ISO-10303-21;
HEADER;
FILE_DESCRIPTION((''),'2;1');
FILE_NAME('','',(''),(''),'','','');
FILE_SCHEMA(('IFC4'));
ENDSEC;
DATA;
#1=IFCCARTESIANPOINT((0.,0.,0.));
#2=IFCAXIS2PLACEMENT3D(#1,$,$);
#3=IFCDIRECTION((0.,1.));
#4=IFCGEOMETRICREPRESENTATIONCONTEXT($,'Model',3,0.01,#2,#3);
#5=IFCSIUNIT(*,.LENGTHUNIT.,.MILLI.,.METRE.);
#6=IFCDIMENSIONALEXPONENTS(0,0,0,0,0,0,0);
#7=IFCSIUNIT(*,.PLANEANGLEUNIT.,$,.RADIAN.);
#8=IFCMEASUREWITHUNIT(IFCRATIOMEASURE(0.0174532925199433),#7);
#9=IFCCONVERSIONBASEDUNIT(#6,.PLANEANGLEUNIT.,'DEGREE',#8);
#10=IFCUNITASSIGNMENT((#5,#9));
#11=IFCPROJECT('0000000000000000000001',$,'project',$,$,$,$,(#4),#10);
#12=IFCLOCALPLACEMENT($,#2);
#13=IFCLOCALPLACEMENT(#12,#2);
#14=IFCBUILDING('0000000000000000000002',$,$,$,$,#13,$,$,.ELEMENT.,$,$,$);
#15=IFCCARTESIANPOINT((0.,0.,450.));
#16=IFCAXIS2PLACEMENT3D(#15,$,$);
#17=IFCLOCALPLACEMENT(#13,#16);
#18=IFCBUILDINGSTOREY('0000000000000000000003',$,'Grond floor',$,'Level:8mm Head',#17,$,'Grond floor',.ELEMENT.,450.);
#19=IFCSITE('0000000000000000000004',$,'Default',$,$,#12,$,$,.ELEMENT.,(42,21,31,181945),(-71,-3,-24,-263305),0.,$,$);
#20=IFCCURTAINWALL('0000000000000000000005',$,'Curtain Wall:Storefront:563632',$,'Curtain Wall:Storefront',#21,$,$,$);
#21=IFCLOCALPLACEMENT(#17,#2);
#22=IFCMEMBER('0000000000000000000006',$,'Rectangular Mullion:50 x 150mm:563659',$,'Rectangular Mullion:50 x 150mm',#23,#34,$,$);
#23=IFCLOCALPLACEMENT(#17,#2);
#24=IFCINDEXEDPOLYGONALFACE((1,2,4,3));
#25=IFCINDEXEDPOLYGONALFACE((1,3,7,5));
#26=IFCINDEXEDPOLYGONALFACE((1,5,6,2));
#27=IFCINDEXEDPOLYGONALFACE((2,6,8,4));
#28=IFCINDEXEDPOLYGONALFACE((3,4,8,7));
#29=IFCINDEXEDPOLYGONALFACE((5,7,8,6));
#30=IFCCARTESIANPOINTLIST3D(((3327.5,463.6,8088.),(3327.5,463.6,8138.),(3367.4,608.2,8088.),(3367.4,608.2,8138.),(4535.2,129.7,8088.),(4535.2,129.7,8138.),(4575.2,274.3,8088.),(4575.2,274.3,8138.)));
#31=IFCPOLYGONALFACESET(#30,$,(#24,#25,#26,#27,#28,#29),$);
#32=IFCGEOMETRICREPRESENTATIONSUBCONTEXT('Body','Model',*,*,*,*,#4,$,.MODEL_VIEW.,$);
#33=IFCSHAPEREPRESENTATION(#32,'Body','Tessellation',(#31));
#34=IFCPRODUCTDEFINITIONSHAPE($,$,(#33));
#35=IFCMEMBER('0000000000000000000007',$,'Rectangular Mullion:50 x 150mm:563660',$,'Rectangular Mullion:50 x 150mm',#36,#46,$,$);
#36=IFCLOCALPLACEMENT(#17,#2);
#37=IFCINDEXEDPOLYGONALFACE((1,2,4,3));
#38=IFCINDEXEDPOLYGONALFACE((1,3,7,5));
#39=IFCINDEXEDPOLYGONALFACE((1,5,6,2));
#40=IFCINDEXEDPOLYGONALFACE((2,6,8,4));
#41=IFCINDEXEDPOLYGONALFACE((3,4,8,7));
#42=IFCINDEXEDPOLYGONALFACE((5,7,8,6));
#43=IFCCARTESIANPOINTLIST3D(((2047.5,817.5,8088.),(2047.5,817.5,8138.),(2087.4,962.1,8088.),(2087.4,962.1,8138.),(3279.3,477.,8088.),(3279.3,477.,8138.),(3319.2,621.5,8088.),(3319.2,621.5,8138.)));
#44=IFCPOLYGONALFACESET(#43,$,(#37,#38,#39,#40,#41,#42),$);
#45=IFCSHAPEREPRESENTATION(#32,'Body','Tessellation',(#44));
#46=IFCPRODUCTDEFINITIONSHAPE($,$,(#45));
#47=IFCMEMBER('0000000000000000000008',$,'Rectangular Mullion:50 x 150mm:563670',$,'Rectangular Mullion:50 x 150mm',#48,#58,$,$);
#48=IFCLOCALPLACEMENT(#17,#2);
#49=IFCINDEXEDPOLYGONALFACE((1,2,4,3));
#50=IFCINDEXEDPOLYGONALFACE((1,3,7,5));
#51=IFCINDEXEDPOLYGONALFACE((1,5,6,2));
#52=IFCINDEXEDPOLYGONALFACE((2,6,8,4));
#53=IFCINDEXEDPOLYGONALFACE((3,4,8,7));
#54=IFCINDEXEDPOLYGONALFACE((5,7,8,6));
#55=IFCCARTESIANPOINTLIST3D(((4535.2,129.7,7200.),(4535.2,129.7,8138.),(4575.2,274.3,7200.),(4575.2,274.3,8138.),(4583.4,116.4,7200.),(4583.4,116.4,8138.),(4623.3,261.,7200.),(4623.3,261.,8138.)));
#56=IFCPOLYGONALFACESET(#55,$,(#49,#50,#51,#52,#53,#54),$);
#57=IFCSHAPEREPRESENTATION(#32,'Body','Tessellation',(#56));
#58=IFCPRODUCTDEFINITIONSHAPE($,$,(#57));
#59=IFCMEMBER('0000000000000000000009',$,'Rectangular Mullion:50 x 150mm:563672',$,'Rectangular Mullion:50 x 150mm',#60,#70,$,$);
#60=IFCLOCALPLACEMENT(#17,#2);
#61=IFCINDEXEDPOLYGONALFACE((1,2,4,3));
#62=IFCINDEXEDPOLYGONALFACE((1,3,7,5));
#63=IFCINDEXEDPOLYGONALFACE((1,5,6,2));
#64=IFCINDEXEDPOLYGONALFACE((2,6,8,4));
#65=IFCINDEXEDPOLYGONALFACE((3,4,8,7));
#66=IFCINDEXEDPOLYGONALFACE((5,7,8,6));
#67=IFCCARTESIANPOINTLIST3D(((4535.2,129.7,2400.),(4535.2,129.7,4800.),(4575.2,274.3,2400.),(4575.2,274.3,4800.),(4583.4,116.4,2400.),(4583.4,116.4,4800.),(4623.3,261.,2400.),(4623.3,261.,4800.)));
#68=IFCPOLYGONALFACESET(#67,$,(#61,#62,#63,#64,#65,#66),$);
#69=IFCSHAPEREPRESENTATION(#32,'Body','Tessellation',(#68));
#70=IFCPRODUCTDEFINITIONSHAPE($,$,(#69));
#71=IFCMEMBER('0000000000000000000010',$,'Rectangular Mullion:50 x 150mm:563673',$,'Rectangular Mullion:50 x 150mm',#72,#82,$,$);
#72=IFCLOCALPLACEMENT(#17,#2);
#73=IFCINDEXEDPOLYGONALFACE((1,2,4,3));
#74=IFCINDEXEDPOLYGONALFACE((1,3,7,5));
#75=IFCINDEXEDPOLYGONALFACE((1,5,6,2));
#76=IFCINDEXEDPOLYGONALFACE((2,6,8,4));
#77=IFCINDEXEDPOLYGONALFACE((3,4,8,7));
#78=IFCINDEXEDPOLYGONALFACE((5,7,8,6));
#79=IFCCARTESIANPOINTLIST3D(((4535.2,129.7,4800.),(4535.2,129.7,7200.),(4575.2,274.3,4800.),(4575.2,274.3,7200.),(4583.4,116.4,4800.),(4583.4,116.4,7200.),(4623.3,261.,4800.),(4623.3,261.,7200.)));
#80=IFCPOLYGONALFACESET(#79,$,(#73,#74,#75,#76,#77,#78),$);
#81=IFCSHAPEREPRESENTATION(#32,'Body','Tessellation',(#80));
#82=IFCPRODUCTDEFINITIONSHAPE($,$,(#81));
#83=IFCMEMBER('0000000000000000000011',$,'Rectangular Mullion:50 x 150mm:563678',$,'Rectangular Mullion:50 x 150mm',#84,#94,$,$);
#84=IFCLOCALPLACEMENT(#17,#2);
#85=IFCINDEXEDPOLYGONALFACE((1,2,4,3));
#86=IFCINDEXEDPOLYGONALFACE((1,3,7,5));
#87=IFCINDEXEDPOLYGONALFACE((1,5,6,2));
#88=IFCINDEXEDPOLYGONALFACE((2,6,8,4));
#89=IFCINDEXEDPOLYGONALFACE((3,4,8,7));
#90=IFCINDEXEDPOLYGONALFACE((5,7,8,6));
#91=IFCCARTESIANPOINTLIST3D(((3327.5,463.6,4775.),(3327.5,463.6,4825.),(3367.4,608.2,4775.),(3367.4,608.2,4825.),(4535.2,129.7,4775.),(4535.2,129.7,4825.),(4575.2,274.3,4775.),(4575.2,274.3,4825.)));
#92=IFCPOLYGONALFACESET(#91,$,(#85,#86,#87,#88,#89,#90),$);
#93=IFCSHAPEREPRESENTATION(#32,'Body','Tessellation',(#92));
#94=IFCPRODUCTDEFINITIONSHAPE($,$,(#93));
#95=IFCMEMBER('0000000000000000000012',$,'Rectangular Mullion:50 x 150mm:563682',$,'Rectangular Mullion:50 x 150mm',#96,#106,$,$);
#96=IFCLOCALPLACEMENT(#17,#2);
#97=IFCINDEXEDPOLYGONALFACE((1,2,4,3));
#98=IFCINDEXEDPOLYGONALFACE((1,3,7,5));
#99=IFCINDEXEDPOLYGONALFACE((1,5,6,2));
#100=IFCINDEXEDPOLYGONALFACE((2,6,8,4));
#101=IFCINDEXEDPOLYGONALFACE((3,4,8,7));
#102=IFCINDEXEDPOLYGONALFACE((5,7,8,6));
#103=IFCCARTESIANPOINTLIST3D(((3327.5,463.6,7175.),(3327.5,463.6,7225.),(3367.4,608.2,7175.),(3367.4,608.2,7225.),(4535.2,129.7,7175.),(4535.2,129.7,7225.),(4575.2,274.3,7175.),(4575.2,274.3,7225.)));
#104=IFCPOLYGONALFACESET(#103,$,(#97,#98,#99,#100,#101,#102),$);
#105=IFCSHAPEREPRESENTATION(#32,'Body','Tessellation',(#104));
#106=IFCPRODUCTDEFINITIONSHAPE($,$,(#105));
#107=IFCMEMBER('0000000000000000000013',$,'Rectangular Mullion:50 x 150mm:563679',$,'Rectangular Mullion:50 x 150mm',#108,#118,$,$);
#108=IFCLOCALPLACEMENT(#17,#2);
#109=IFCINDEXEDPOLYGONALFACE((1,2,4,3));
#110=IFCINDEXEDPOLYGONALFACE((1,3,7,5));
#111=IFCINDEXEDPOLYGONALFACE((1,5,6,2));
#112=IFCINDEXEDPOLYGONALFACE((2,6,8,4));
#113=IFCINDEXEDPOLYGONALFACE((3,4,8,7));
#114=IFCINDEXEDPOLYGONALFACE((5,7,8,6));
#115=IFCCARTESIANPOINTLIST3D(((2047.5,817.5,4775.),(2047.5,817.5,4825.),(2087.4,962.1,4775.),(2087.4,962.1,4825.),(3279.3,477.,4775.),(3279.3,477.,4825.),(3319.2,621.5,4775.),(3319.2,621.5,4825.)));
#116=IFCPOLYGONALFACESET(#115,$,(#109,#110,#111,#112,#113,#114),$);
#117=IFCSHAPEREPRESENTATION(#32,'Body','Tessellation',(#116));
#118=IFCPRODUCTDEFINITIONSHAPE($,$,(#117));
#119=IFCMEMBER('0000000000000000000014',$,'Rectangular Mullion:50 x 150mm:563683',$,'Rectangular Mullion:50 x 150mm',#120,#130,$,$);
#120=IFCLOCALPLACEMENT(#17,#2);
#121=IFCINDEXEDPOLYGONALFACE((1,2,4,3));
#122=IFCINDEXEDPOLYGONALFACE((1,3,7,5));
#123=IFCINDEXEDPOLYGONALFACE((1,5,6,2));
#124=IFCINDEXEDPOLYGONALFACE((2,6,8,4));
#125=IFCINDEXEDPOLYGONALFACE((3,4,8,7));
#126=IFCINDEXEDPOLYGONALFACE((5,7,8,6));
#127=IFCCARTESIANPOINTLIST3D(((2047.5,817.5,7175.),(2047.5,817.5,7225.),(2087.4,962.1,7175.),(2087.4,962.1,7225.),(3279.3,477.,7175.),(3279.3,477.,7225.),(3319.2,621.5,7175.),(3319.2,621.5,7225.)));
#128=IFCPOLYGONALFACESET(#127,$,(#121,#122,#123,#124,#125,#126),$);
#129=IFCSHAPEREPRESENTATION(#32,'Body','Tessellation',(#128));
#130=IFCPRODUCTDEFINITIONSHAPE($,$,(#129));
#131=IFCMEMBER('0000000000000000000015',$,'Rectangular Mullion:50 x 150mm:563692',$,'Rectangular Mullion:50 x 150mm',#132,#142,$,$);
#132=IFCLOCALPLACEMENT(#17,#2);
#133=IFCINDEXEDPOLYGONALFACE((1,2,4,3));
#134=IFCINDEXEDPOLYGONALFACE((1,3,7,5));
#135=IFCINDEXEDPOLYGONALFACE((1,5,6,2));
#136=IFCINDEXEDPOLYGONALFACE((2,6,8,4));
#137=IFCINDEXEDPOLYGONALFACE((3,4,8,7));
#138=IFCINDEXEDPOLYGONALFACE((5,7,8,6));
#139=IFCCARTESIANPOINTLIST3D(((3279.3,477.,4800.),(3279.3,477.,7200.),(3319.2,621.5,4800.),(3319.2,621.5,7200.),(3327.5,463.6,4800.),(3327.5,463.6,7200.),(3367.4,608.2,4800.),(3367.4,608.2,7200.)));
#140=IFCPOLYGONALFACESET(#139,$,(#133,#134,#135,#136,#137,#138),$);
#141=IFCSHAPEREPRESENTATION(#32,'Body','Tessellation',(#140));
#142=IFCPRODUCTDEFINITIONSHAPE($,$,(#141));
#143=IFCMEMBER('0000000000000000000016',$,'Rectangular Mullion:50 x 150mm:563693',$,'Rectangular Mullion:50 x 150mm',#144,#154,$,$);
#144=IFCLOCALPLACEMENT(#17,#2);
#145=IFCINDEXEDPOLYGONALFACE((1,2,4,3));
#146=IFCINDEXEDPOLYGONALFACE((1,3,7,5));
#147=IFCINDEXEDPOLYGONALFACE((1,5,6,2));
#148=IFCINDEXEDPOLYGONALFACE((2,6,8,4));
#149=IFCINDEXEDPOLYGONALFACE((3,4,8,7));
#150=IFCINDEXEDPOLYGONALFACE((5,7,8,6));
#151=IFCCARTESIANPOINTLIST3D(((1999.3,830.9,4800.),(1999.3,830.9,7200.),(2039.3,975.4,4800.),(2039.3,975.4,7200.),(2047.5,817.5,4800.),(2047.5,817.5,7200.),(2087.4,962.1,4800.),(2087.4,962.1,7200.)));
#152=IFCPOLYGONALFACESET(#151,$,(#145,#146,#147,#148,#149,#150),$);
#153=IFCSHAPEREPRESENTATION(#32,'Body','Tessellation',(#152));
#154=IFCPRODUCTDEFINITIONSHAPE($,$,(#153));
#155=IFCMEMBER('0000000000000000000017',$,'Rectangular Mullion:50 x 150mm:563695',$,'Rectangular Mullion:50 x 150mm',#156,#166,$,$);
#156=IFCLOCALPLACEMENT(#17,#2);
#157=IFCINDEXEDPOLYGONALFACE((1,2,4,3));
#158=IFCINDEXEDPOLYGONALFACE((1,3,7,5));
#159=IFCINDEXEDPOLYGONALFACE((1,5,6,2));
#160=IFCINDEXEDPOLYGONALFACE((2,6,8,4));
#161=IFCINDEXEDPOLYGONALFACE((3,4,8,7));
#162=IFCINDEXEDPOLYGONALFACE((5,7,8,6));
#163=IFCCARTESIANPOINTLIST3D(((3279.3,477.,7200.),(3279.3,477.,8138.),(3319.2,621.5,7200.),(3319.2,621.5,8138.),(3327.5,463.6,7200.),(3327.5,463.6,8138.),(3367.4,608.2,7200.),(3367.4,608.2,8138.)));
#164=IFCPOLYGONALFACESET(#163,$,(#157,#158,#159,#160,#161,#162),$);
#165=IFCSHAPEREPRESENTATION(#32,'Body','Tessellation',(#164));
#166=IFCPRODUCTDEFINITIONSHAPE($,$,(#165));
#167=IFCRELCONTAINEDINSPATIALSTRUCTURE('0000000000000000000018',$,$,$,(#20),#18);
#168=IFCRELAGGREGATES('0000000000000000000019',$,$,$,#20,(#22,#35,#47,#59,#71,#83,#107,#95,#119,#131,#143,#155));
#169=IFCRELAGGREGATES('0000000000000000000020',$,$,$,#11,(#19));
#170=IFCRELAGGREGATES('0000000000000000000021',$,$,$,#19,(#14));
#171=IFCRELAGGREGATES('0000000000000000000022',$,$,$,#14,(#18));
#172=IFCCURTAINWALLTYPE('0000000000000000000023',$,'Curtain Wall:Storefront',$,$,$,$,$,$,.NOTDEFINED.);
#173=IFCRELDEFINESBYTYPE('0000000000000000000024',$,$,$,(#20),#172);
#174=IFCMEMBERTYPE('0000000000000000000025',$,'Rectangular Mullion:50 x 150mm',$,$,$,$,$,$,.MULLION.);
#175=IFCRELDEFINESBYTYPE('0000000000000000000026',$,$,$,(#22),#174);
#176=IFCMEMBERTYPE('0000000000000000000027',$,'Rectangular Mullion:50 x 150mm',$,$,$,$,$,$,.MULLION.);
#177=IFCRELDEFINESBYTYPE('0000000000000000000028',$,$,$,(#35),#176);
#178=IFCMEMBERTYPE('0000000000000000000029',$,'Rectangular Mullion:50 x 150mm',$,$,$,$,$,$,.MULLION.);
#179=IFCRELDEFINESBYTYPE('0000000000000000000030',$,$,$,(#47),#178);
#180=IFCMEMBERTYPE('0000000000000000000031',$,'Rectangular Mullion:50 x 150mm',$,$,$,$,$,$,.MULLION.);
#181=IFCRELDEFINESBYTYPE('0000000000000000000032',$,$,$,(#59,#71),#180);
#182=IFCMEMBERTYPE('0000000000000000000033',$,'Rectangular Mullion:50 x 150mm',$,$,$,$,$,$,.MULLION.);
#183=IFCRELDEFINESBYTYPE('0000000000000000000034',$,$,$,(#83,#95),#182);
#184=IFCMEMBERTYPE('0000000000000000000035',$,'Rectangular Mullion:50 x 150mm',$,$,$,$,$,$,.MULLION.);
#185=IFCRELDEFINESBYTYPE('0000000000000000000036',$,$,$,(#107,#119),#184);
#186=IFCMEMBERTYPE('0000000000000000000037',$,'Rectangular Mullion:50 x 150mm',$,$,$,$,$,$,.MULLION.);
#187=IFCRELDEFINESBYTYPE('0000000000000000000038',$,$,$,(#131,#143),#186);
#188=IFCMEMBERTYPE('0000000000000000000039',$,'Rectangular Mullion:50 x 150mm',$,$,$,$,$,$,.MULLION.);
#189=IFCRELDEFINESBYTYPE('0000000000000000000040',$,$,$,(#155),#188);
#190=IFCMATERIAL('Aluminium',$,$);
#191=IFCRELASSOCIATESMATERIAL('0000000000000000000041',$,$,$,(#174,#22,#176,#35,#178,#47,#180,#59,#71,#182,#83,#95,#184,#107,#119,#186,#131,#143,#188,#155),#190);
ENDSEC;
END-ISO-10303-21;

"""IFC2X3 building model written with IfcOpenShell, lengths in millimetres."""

from ifc_helpers import new_model, entity, si_unit, converted_unit, direction, frame, origin, origin_2d_with_axis, place, context, subcontext, project, spatial, rectangle, extrude, source, transform, mapped, material, type_object, type_shapes, element, aggregate, save


model = new_model("IFC2X3")

# Units and contexts
model_context = context("Model", 3, precision=0.01, world=origin(), true_north=direction((0.0, 1.0)))
body_context = subcontext(model_context, "Body", "Model", "MODEL_VIEW")
ifc_project = project(units=[si_unit("LENGTHUNIT", "METRE", prefix="MILLI"), converted_unit("PLANEANGLEUNIT", "DEGREE", entity("IfcRatioMeasure", 0.0174532925199433), si_unit("PLANEANGLEUNIT", "RADIAN"), dimensions=[0, 0, 0, 0, 0, 0, 0])], contexts=[model_context])

# Site, building, storey
site_placement = place(None, origin())
site = spatial("IfcSite", under=ifc_project, at=site_placement, Name="Default", CompositionType="ELEMENT", RefLatitude=(42, 21, 31, 181945), RefLongitude=(-71, -3, -24, -263305), RefElevation=0.0)
building_placement = place(site_placement, origin())
building = spatial("IfcBuilding", under=site, at=building_placement, CompositionType="ELEMENT")
storey_placement = place(building_placement, frame((0.0, 0.0, 450.0)))
storey = spatial("IfcBuildingStorey", under=building, at=storey_placement, Name="Grond floor", ObjectType="Level:8mm Head", LongName="Grond floor", CompositionType="ELEMENT", Elevation=450.0)

# Curtain wall, members
curtain_wall_type = type_object("IfcCurtainWallType", Name="Curtain Wall:Storefront", PredefinedType="NOTDEFINED")
curtain_wall_placement = place(storey_placement, frame((0.0, 0.0, -450.0)))
curtain_wall = element("IfcCurtainWall", 1, at=curtain_wall_placement, inside=storey, type_object=curtain_wall_type, Name="Curtain Wall:Storefront:563632", ObjectType="Curtain Wall:Storefront")
ifc_material_1 = material(Name="Aluminium")
member_type_1 = type_object("IfcMemberType", Name="Rectangular Mullion:50 x 150mm", PredefinedType="MULLION", material=ifc_material_1)
shared_shape_1 = source(origin(), body_context, "Body", "SweptSolid", [
    extrude(rectangle(XDim=150.0, YDim=50.0, at=origin_2d_with_axis()), frame((-25.0, 0.0, -1253.0), z_axis=(0.0, 0.0, 1.0), x_axis=(0.0, -1.0, 0.0)), (0.0, 0.0, 1.0), 1253.0),
])
type_shapes(member_type_1, [shared_shape_1])
member_1_placement = place(storey_placement, frame((3347.5, 535.9, 8138.0), z_axis=(-0.963836, 0.266496, 0.0), x_axis=(0.0, 0.0, 1.0)))
member_1 = element("IfcMember", 2, at=member_1_placement, type_object=member_type_1, material=ifc_material_1, Name="Rectangular Mullion:50 x 150mm:563659", ObjectType="Rectangular Mullion:50 x 150mm", context=body_context, shape_type="MappedRepresentation", body=[
    mapped(shared_shape_1, transform((0.0, 0.0, 0.0), scale=1.0)),
])
member_type_2 = type_object("IfcMemberType", Name="Rectangular Mullion:50 x 150mm", PredefinedType="MULLION", material=ifc_material_1)
shared_shape_2 = source(origin(), body_context, "Body", "SweptSolid", [
    extrude(rectangle(XDim=150.0, YDim=50.0, at=origin_2d_with_axis()), frame((-25.0, 0.0, -1278.0), z_axis=(0.0, 0.0, 1.0), x_axis=(0.0, -1.0, 0.0)), (0.0, 0.0, 1.0), 1278.0),
])
type_shapes(member_type_2, [shared_shape_2])
member_2_placement = place(storey_placement, frame((2067.5, 889.8, 8138.0), z_axis=(-0.963836, 0.266496, 0.0), x_axis=(0.0, 0.0, 1.0)))
member_2 = element("IfcMember", 3, at=member_2_placement, type_object=member_type_2, material=ifc_material_1, Name="Rectangular Mullion:50 x 150mm:563660", ObjectType="Rectangular Mullion:50 x 150mm", context=body_context, shape_type="MappedRepresentation", body=[
    mapped(shared_shape_2, transform((0.0, 0.0, 0.0), scale=1.0)),
])
member_type_3 = type_object("IfcMemberType", Name="Rectangular Mullion:50 x 150mm", PredefinedType="MULLION", material=ifc_material_1)
shared_shape_3 = source(origin(), body_context, "Body", "SweptSolid", [
    extrude(rectangle(XDim=150.0, YDim=50.0, at=origin_2d_with_axis()), frame((-25.0, 0.0, -938.0), z_axis=(0.0, 0.0, 1.0), x_axis=(0.0, -1.0, 0.0)), (0.0, 0.0, 1.0), 938.0),
])
type_shapes(member_type_3, [shared_shape_3])
member_3_placement = place(storey_placement, frame((4603.4, 188.7, 8138.0), z_axis=(0.0, 0.0, 1.0), x_axis=(0.963836, -0.266496, 0.0)))
member_3 = element("IfcMember", 4, at=member_3_placement, type_object=member_type_3, material=ifc_material_1, Name="Rectangular Mullion:50 x 150mm:563670", ObjectType="Rectangular Mullion:50 x 150mm", context=body_context, shape_type="MappedRepresentation", body=[
    mapped(shared_shape_3, transform((0.0, 0.0, 0.0), scale=1.0)),
])
member_type_4 = type_object("IfcMemberType", Name="Rectangular Mullion:50 x 150mm", PredefinedType="MULLION", material=ifc_material_1)
shared_shape_4 = source(origin(), body_context, "Body", "SweptSolid", [
    extrude(rectangle(XDim=150.0, YDim=50.0, at=origin_2d_with_axis()), frame((-25.0, 0.0, -2400.0), z_axis=(0.0, 0.0, 1.0), x_axis=(0.0, -1.0, 0.0)), (0.0, 0.0, 1.0), 2400.0),
])
type_shapes(member_type_4, [shared_shape_4])
member_4_placement = place(storey_placement, frame((4603.4, 188.7, 4800.0), z_axis=(0.0, 0.0, 1.0), x_axis=(0.963836, -0.266496, 0.0)))
member_4 = element("IfcMember", 5, at=member_4_placement, type_object=member_type_4, material=ifc_material_1, Name="Rectangular Mullion:50 x 150mm:563672", ObjectType="Rectangular Mullion:50 x 150mm", context=body_context, shape_type="MappedRepresentation", body=[
    mapped(shared_shape_4, transform((0.0, 0.0, 0.0), scale=1.0)),
])
member_5_placement = place(storey_placement, frame((4603.4, 188.7, 7200.0), z_axis=(0.0, 0.0, 1.0), x_axis=(0.963836, -0.266496, 0.0)))
member_5 = element("IfcMember", 6, at=member_5_placement, type_object=member_type_4, material=ifc_material_1, Name="Rectangular Mullion:50 x 150mm:563673", ObjectType="Rectangular Mullion:50 x 150mm", context=body_context, shape_type="MappedRepresentation", body=[
    mapped(shared_shape_4, transform((0.0, 0.0, 0.0), scale=1.0)),
])
member_type_5 = type_object("IfcMemberType", Name="Rectangular Mullion:50 x 150mm", PredefinedType="MULLION", material=ifc_material_1)
shared_shape_5 = source(origin(), body_context, "Body", "SweptSolid", [
    extrude(rectangle(XDim=150.0, YDim=50.0, at=origin_2d_with_axis()), frame((0.0, 0.0, -1253.0), z_axis=(0.0, 0.0, 1.0), x_axis=(0.0, -1.0, 0.0)), (0.0, 0.0, 1.0), 1253.0),
])
type_shapes(member_type_5, [shared_shape_5])
member_6_placement = place(storey_placement, frame((3347.5, 535.9, 4800.0), z_axis=(-0.963836, 0.266496, 0.0), x_axis=(0.0, 0.0, 1.0)))
member_6 = element("IfcMember", 7, at=member_6_placement, type_object=member_type_5, material=ifc_material_1, Name="Rectangular Mullion:50 x 150mm:563678", ObjectType="Rectangular Mullion:50 x 150mm", context=body_context, shape_type="MappedRepresentation", body=[
    mapped(shared_shape_5, transform((0.0, 0.0, 0.0), scale=1.0)),
])
member_7_placement = place(storey_placement, frame((3347.5, 535.9, 7200.0), z_axis=(-0.963836, 0.266496, 0.0), x_axis=(0.0, 0.0, 1.0)))
member_7 = element("IfcMember", 8, at=member_7_placement, type_object=member_type_5, material=ifc_material_1, Name="Rectangular Mullion:50 x 150mm:563682", ObjectType="Rectangular Mullion:50 x 150mm", context=body_context, shape_type="MappedRepresentation", body=[
    mapped(shared_shape_5, transform((0.0, 0.0, 0.0), scale=1.0)),
])
member_type_6 = type_object("IfcMemberType", Name="Rectangular Mullion:50 x 150mm", PredefinedType="MULLION", material=ifc_material_1)
shared_shape_6 = source(origin(), body_context, "Body", "SweptSolid", [
    extrude(rectangle(XDim=150.0, YDim=50.0, at=origin_2d_with_axis()), frame((0.0, 0.0, -1278.0), z_axis=(0.0, 0.0, 1.0), x_axis=(0.0, -1.0, 0.0)), (0.0, 0.0, 1.0), 1278.0),
])
type_shapes(member_type_6, [shared_shape_6])
member_8_placement = place(storey_placement, frame((2067.5, 889.8, 4800.0), z_axis=(-0.963836, 0.266496, 0.0), x_axis=(0.0, 0.0, 1.0)))
member_8 = element("IfcMember", 9, at=member_8_placement, type_object=member_type_6, material=ifc_material_1, Name="Rectangular Mullion:50 x 150mm:563679", ObjectType="Rectangular Mullion:50 x 150mm", context=body_context, shape_type="MappedRepresentation", body=[
    mapped(shared_shape_6, transform((0.0, 0.0, 0.0), scale=1.0)),
])
member_9_placement = place(storey_placement, frame((2067.5, 889.8, 7200.0), z_axis=(-0.963836, 0.266496, 0.0), x_axis=(0.0, 0.0, 1.0)))
member_9 = element("IfcMember", 10, at=member_9_placement, type_object=member_type_6, material=ifc_material_1, Name="Rectangular Mullion:50 x 150mm:563683", ObjectType="Rectangular Mullion:50 x 150mm", context=body_context, shape_type="MappedRepresentation", body=[
    mapped(shared_shape_6, transform((0.0, 0.0, 0.0), scale=1.0)),
])
member_type_7 = type_object("IfcMemberType", Name="Rectangular Mullion:50 x 150mm", PredefinedType="MULLION", material=ifc_material_1)
shared_shape_7 = source(origin(), body_context, "Body", "SweptSolid", [
    extrude(rectangle(XDim=150.0, YDim=50.0, at=origin_2d_with_axis()), frame((0.0, 0.0, -2400.0), z_axis=(0.0, 0.0, 1.0), x_axis=(0.0, -1.0, 0.0)), (0.0, 0.0, 1.0), 2400.0),
])
type_shapes(member_type_7, [shared_shape_7])
member_10_placement = place(storey_placement, frame((3323.4, 542.6, 4800.0), z_axis=(0.0, 0.0, -1.0), x_axis=(-0.963836, 0.266496, 0.0)))
member_10 = element("IfcMember", 11, at=member_10_placement, type_object=member_type_7, material=ifc_material_1, Name="Rectangular Mullion:50 x 150mm:563692", ObjectType="Rectangular Mullion:50 x 150mm", context=body_context, shape_type="MappedRepresentation", body=[
    mapped(shared_shape_7, transform((0.0, 0.0, 0.0), scale=1.0)),
])
member_11_placement = place(storey_placement, frame((2043.4, 896.5, 4800.0), z_axis=(0.0, 0.0, -1.0), x_axis=(-0.963836, 0.266496, 0.0)))
member_11 = element("IfcMember", 12, at=member_11_placement, type_object=member_type_7, material=ifc_material_1, Name="Rectangular Mullion:50 x 150mm:563693", ObjectType="Rectangular Mullion:50 x 150mm", context=body_context, shape_type="MappedRepresentation", body=[
    mapped(shared_shape_7, transform((0.0, 0.0, 0.0), scale=1.0)),
])
member_type_8 = type_object("IfcMemberType", Name="Rectangular Mullion:50 x 150mm", PredefinedType="MULLION", material=ifc_material_1)
shared_shape_8 = source(origin(), body_context, "Body", "SweptSolid", [
    extrude(rectangle(XDim=150.0, YDim=50.0, at=origin_2d_with_axis()), frame((0.0, 0.0, -938.0), z_axis=(0.0, 0.0, 1.0), x_axis=(0.0, -1.0, 0.0)), (0.0, 0.0, 1.0), 938.0),
])
type_shapes(member_type_8, [shared_shape_8])
member_12_placement = place(storey_placement, frame((3323.4, 542.6, 7200.0), z_axis=(0.0, 0.0, -1.0), x_axis=(-0.963836, 0.266496, 0.0)))
member_12 = element("IfcMember", 13, at=member_12_placement, type_object=member_type_8, material=ifc_material_1, Name="Rectangular Mullion:50 x 150mm:563695", ObjectType="Rectangular Mullion:50 x 150mm", context=body_context, shape_type="MappedRepresentation", body=[
    mapped(shared_shape_8, transform((0.0, 0.0, 0.0), scale=1.0)),
])
aggregate(curtain_wall, [member_1, member_2, member_3, member_4, member_5, member_6, member_8, member_7, member_9, member_10, member_11, member_12])

save(model, "model.ifc")
